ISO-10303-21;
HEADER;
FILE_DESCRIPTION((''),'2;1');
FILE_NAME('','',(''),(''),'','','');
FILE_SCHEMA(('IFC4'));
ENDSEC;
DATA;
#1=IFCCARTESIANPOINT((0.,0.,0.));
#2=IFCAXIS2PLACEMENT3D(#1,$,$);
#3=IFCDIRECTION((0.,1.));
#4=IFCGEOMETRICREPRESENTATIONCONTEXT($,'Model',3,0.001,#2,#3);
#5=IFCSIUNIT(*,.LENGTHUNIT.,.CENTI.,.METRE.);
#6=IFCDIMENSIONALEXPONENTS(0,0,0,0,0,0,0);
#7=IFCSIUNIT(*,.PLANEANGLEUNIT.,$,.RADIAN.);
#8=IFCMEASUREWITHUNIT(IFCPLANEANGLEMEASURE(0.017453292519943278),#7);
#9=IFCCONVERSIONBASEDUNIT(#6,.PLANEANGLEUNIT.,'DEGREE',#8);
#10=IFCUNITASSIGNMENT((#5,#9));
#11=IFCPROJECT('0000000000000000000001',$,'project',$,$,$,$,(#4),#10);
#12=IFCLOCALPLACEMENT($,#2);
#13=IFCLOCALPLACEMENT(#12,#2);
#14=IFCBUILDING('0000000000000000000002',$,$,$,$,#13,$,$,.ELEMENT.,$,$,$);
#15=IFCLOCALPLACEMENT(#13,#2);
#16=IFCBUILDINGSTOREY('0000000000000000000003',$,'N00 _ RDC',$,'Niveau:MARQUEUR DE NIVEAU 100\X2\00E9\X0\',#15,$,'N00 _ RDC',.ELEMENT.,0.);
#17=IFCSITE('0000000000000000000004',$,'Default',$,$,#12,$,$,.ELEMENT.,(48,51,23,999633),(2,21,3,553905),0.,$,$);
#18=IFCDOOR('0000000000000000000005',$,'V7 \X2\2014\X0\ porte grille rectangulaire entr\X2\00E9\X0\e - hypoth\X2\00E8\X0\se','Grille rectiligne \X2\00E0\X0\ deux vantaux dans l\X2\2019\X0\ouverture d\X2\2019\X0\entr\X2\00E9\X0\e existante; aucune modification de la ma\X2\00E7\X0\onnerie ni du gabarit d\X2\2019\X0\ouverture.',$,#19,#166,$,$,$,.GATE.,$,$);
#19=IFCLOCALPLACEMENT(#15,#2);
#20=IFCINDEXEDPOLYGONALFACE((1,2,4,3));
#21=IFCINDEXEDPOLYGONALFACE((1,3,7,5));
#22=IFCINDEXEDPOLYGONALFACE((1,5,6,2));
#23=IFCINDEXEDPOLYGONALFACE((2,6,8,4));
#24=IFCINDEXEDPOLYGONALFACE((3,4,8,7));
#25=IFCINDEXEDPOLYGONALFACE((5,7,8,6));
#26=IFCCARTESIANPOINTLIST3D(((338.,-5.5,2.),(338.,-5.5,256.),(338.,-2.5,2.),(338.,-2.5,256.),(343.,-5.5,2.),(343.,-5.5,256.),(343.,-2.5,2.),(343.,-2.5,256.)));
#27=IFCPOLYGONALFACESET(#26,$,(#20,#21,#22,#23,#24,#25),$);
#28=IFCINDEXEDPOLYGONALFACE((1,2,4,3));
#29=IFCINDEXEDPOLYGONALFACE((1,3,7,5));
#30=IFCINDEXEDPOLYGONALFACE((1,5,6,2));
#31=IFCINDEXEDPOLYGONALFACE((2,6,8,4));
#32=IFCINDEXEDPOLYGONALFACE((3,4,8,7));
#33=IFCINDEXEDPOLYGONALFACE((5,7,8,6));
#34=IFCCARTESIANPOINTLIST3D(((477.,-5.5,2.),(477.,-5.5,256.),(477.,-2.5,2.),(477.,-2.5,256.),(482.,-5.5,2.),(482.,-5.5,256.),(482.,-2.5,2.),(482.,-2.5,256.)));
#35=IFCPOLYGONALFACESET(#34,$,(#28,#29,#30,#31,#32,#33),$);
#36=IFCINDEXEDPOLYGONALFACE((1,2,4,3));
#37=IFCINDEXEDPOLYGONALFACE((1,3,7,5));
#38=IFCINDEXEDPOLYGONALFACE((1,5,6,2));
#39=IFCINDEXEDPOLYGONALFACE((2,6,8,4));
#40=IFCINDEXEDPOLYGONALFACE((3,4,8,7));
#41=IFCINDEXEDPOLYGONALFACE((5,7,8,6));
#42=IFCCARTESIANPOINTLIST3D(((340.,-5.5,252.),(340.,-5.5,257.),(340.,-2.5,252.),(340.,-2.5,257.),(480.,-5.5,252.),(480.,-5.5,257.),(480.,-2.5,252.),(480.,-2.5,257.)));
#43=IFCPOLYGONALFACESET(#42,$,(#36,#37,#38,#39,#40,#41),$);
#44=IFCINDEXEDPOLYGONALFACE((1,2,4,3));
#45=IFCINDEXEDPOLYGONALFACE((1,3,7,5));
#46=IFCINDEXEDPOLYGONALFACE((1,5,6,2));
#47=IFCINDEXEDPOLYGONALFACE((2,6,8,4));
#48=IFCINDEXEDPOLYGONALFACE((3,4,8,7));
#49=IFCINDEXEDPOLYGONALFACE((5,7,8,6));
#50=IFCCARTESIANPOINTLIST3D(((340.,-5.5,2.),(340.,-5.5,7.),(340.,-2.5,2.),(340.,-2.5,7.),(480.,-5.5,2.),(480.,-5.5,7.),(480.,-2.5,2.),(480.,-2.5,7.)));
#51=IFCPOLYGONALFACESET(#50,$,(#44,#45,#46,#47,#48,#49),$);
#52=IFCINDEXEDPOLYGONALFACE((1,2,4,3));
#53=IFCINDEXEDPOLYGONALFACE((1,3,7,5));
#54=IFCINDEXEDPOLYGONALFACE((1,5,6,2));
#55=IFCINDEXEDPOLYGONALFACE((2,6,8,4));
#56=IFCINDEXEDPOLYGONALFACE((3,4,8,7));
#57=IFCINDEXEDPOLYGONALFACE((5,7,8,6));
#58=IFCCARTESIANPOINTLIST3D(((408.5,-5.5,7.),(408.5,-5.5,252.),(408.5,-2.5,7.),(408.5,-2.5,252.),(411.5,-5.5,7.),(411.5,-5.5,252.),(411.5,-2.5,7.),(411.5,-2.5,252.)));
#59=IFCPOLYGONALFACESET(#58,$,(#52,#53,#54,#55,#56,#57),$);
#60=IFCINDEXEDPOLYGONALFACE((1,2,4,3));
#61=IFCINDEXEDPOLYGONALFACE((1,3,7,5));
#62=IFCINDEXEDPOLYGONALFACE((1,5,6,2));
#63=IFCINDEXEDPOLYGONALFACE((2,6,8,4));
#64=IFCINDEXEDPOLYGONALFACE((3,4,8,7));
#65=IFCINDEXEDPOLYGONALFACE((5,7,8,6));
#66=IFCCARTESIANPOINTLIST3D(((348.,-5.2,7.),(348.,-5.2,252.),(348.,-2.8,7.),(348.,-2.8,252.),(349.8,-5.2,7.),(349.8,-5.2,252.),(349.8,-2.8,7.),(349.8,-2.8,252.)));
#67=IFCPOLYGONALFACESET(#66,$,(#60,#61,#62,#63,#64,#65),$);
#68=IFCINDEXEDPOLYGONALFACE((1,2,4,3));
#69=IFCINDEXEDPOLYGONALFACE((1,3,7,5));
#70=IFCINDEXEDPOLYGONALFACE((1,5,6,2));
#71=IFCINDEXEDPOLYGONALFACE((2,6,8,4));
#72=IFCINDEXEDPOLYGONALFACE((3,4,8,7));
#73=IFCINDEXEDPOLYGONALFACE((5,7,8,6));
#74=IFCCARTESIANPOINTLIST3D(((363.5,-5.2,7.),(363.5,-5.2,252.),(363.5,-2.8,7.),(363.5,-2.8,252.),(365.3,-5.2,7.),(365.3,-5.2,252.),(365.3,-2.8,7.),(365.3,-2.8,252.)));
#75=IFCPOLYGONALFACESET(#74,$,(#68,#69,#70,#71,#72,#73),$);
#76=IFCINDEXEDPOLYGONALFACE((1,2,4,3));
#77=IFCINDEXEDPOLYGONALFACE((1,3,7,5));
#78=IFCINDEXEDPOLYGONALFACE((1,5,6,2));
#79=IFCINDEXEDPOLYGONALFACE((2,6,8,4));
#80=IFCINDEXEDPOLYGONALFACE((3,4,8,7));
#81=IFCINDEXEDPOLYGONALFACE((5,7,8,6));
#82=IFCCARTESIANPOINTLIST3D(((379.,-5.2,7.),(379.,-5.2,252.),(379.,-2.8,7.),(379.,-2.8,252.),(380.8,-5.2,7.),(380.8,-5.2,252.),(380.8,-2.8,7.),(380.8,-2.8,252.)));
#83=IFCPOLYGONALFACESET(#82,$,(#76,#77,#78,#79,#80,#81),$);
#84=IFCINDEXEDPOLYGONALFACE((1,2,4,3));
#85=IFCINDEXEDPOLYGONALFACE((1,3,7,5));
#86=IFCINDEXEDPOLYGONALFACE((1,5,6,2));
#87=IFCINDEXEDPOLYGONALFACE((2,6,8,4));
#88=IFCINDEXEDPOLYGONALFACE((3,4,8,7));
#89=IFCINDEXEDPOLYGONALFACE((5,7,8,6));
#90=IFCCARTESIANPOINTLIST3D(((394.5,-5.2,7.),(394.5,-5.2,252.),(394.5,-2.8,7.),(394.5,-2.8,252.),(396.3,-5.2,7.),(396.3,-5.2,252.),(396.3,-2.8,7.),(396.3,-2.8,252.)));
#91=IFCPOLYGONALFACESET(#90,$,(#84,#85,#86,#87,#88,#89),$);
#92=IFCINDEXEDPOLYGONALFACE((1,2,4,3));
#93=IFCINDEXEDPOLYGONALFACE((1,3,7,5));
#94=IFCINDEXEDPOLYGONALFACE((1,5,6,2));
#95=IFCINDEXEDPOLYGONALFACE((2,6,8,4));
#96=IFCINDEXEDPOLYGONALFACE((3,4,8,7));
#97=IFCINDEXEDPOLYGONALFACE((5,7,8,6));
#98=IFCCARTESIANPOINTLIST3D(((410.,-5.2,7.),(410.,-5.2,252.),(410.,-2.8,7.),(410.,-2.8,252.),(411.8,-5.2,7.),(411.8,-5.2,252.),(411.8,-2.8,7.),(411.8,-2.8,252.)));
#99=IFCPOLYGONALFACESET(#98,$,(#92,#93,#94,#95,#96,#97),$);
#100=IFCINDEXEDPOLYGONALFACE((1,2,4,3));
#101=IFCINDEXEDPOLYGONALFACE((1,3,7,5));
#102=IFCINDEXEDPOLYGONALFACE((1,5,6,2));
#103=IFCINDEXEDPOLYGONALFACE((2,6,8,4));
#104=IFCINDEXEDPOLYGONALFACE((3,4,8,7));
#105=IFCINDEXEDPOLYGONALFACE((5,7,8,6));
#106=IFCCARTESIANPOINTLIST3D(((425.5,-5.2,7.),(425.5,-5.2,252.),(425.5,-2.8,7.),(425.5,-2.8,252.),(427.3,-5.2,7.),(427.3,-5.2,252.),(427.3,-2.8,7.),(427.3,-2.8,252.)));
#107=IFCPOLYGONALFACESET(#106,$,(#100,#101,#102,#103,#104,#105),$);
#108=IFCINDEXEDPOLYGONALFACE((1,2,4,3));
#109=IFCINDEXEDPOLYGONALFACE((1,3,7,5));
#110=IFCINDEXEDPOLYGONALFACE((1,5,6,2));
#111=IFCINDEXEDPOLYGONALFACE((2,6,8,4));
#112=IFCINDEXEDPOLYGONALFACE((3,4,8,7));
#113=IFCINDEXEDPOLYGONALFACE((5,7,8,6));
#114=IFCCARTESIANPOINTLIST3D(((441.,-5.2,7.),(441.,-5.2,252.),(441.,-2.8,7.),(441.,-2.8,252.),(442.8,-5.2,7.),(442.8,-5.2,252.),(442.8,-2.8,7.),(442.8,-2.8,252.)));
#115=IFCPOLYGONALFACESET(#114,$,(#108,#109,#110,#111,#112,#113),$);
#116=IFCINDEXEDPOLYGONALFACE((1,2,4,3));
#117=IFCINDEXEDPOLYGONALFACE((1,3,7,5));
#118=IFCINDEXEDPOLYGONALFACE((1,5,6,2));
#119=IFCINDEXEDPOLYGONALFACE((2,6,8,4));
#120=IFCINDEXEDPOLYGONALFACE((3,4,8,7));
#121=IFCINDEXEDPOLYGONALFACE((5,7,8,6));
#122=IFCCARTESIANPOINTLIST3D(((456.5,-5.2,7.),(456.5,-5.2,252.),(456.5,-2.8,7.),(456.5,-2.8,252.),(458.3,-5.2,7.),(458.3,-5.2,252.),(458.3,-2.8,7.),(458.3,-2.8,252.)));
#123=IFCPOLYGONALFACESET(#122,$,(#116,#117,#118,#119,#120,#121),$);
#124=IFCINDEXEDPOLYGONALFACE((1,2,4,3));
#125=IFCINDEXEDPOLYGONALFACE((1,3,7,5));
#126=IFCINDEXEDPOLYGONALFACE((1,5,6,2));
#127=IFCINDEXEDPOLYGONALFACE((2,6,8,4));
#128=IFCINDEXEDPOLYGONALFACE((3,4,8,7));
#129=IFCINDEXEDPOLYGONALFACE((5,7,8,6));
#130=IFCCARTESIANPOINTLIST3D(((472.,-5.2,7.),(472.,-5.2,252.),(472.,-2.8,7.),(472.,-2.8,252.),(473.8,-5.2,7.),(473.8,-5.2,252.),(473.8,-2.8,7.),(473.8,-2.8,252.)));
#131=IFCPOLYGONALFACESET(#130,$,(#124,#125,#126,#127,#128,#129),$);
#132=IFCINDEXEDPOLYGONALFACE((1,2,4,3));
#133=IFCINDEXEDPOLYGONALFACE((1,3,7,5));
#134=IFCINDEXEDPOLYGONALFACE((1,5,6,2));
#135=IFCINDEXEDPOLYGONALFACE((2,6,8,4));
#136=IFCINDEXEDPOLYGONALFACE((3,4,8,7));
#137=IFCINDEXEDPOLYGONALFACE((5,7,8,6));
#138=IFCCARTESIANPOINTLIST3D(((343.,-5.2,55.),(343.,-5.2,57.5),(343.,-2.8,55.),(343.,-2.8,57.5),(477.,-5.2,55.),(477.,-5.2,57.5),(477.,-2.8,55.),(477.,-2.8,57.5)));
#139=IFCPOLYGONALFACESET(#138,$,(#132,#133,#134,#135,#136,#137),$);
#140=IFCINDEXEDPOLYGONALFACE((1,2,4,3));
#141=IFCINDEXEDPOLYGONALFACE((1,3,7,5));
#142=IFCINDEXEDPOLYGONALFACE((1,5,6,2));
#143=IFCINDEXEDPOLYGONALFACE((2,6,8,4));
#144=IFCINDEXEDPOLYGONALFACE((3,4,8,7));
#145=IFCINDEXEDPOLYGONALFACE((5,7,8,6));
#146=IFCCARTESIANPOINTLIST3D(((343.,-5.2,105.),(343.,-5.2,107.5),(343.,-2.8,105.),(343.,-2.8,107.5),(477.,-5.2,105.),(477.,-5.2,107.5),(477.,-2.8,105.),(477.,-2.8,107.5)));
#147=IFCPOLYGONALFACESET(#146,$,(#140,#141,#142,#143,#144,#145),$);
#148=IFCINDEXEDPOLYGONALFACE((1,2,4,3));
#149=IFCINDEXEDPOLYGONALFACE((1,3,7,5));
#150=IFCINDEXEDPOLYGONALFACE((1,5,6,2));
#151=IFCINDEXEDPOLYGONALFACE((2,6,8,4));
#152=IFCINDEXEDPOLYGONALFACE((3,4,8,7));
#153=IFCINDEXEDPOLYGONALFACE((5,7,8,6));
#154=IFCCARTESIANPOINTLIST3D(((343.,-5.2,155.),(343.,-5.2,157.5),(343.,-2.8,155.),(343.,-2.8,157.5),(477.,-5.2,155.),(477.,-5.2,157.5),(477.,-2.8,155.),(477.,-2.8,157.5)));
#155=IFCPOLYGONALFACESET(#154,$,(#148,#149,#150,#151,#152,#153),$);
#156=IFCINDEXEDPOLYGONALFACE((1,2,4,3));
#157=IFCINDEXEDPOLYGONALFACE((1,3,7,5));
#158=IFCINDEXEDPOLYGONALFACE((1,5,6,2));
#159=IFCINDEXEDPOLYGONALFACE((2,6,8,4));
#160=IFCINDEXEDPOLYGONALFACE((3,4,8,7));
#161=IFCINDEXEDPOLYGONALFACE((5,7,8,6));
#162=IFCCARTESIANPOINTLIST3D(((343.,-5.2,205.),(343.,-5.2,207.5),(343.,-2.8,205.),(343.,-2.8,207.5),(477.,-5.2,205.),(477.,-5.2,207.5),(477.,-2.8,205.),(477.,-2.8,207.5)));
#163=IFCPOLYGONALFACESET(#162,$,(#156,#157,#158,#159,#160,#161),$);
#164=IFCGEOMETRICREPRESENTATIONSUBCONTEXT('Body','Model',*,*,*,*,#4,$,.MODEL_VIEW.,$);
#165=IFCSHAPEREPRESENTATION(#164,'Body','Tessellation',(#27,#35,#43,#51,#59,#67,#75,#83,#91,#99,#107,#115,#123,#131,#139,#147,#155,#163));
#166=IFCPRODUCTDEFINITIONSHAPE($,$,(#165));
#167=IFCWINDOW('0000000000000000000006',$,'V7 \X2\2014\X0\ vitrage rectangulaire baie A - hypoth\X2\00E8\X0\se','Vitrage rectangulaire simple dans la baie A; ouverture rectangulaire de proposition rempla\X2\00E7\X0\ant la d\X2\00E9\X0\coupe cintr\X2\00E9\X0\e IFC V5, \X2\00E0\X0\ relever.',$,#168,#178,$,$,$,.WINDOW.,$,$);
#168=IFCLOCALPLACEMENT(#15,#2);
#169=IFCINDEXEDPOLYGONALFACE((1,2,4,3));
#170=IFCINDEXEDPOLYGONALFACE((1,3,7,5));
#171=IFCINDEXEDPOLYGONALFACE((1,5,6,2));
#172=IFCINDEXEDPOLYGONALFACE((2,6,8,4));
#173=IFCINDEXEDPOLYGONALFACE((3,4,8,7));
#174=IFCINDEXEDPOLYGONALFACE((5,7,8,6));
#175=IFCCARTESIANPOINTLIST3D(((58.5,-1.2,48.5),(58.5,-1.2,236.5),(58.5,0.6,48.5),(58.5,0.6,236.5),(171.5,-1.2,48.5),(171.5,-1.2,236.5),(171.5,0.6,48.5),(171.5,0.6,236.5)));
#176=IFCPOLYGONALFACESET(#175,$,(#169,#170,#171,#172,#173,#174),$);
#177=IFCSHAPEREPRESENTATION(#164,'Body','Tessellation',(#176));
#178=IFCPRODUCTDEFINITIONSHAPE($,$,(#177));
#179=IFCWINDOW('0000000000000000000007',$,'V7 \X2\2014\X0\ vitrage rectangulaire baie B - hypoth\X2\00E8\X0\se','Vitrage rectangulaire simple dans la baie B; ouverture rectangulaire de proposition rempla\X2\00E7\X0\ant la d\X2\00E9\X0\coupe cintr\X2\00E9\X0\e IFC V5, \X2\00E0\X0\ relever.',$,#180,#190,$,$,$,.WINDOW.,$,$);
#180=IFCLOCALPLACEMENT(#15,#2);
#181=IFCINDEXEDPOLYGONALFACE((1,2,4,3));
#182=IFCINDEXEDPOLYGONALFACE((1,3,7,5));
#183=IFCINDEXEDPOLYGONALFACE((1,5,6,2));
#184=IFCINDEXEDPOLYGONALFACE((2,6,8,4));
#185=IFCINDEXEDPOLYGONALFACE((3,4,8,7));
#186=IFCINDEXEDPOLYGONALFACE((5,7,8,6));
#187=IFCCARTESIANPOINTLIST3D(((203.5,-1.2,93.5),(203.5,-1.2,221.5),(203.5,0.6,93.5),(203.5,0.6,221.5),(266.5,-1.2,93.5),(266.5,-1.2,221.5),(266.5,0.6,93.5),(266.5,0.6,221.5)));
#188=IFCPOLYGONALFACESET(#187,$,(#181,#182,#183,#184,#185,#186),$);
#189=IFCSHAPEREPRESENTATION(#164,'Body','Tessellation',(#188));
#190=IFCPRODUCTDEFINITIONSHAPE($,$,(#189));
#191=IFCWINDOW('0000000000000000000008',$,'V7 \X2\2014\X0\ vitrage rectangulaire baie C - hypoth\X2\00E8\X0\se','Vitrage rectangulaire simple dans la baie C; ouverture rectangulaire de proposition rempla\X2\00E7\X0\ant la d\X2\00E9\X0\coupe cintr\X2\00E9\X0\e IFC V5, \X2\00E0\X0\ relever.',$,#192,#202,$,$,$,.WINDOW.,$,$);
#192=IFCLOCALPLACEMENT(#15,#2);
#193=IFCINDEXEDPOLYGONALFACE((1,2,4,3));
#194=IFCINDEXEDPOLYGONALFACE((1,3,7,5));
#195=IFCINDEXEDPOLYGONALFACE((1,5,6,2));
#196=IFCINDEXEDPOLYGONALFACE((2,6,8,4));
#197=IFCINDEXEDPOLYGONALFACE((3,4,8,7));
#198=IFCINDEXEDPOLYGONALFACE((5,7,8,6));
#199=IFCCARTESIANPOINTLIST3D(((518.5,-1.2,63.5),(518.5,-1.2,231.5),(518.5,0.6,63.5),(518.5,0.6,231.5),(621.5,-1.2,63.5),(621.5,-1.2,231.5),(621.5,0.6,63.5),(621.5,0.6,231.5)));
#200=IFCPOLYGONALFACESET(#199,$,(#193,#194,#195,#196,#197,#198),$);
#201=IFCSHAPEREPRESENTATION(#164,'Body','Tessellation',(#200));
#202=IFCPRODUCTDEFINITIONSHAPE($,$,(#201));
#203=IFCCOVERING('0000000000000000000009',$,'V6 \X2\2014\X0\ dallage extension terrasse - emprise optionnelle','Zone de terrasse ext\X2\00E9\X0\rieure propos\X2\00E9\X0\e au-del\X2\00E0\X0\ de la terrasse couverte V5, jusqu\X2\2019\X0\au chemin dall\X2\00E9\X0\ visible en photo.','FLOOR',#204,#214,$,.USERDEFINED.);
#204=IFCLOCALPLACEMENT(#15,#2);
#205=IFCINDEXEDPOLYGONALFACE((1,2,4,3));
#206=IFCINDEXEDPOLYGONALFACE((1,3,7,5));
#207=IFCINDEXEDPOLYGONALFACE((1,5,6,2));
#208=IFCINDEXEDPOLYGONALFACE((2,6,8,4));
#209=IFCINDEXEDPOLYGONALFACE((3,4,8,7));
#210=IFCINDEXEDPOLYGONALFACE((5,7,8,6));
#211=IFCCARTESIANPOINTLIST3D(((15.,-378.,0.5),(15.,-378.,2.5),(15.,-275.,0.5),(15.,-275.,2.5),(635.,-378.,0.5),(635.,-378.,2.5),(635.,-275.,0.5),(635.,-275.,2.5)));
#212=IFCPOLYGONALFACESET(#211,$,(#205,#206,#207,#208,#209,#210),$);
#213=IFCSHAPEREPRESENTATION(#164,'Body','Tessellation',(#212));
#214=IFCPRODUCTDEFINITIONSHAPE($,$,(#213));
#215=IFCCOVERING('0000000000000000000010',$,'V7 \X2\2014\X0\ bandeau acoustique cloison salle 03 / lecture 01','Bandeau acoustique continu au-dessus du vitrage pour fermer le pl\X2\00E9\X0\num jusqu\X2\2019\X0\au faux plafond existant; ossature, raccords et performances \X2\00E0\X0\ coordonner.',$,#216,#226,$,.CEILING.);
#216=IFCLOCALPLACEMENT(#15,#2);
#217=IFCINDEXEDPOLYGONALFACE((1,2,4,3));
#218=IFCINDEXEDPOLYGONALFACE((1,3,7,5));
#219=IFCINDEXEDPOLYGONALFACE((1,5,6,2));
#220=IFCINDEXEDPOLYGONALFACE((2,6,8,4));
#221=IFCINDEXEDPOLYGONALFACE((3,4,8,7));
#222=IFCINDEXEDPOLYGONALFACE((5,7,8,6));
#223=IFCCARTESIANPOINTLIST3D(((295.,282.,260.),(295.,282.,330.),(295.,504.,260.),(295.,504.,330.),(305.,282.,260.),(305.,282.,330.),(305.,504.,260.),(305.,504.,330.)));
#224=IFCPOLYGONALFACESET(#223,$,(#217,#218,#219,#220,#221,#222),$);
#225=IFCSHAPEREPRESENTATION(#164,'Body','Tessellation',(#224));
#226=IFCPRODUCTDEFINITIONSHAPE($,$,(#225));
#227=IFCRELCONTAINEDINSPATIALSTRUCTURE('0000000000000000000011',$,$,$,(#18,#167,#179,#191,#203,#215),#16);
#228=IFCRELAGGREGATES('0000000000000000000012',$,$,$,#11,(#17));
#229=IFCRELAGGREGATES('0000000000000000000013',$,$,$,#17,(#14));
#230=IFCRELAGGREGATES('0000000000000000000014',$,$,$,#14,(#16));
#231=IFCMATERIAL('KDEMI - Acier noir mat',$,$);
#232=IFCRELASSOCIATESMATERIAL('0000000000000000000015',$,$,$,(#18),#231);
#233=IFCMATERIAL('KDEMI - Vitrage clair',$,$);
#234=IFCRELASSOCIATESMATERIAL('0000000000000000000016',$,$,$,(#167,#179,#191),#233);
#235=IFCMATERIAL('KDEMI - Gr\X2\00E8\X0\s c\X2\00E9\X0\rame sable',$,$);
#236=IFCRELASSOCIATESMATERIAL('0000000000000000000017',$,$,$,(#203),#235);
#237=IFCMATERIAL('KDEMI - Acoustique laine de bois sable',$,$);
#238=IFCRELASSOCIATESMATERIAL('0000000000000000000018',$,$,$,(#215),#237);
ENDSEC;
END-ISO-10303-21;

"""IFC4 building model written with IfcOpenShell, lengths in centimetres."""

from ifc_helpers import new_model, entity, si_unit, converted_unit, direction, frame, frame_2d, origin, origin_with_axes, place, context, subcontext, project, spatial, rectangle, extrude, material, element, save


model = new_model("IFC4")

# Units and contexts
model_context = context("Model", 3, precision=0.001, world=origin(), true_north=direction((0.0, 1.0)))
body_context = subcontext(model_context, "Body", "Model", "MODEL_VIEW")
ifc_project = project(units=[si_unit("LENGTHUNIT", "METRE", prefix="CENTI"), converted_unit("PLANEANGLEUNIT", "DEGREE", entity("IfcPlaneAngleMeasure", 0.017453292519943278), si_unit("PLANEANGLEUNIT", "RADIAN"), dimensions=[0, 0, 0, 0, 0, 0, 0])], contexts=[model_context])

# Site, building, storey
site_placement = place(None, origin())
site = spatial("IfcSite", under=ifc_project, at=site_placement, Name="Default", CompositionType="ELEMENT", RefLatitude=(48, 51, 23, 999633), RefLongitude=(2, 21, 3, 553905), RefElevation=0.0)
building_placement = place(site_placement, origin())
building = spatial("IfcBuilding", under=site, at=building_placement, CompositionType="ELEMENT")
storey_placement = place(building_placement, origin())
storey = spatial("IfcBuildingStorey", under=building, at=storey_placement, Name="N00 _ RDC", ObjectType="Niveau:MARQUEUR DE NIVEAU 100é", LongName="N00 _ RDC", CompositionType="ELEMENT", Elevation=0.0)

# Shared definitions
ifc_material_1 = material(Name="KDEMI - Acier noir mat")

# Shared definitions
ifc_material_2 = material(Name="KDEMI - Vitrage clair")

# Door
door_1_placement = place(storey_placement, origin_with_axes())
element("IfcDoor", 1, at=door_1_placement, inside=storey, material=ifc_material_1, Name="V7 — porte grille rectangulaire entrée - hypothèse", Description="Grille rectiligne à deux vantaux dans l’ouverture d’entrée existante; aucune modification de la maçonnerie ni du gabarit d’ouverture.", PredefinedType="GATE", context=body_context, shape_type="SweptSolid", body=[
    extrude(rectangle(XDim=5.0, YDim=3.0, at=frame_2d((340.5, -4.0))), frame((0.0, 0.0, 2.0)), (0.0, 0.0, 1.0), 254.0),
    extrude(rectangle(XDim=5.0, YDim=3.0, at=frame_2d((479.5, -4.0))), frame((0.0, 0.0, 2.0)), (0.0, 0.0, 1.0), 254.0),
    extrude(rectangle(XDim=140.0, YDim=3.0, at=frame_2d((410.0, -4.0))), frame((0.0, 0.0, 252.0)), (0.0, 0.0, 1.0), 5.0),
    extrude(rectangle(XDim=140.0, YDim=3.0, at=frame_2d((410.0, -4.0))), frame((0.0, 0.0, 2.0)), (0.0, 0.0, 1.0), 5.0),
    extrude(rectangle(XDim=3.0, YDim=3.0, at=frame_2d((410.0, -4.0))), frame((0.0, 0.0, 7.0)), (0.0, 0.0, 1.0), 245.0),
    extrude(rectangle(XDim=1.8, YDim=2.4, at=frame_2d((348.9, -4.0))), frame((0.0, 0.0, 7.0)), (0.0, 0.0, 1.0), 245.0),
    extrude(rectangle(XDim=1.8, YDim=2.4, at=frame_2d((364.4, -4.0))), frame((0.0, 0.0, 7.0)), (0.0, 0.0, 1.0), 245.0),
    extrude(rectangle(XDim=1.8, YDim=2.4, at=frame_2d((379.9, -4.0))), frame((0.0, 0.0, 7.0)), (0.0, 0.0, 1.0), 245.0),
    extrude(rectangle(XDim=1.8, YDim=2.4, at=frame_2d((395.4, -4.0))), frame((0.0, 0.0, 7.0)), (0.0, 0.0, 1.0), 245.0),
    extrude(rectangle(XDim=1.8, YDim=2.4, at=frame_2d((410.9, -4.0))), frame((0.0, 0.0, 7.0)), (0.0, 0.0, 1.0), 245.0),
    extrude(rectangle(XDim=1.8, YDim=2.4, at=frame_2d((426.4, -4.0))), frame((0.0, 0.0, 7.0)), (0.0, 0.0, 1.0), 245.0),
    extrude(rectangle(XDim=1.8, YDim=2.4, at=frame_2d((441.9, -4.0))), frame((0.0, 0.0, 7.0)), (0.0, 0.0, 1.0), 245.0),
    extrude(rectangle(XDim=1.8, YDim=2.4, at=frame_2d((457.4, -4.0))), frame((0.0, 0.0, 7.0)), (0.0, 0.0, 1.0), 245.0),
    extrude(rectangle(XDim=1.8, YDim=2.4, at=frame_2d((472.9, -4.0))), frame((0.0, 0.0, 7.0)), (0.0, 0.0, 1.0), 245.0),
    extrude(rectangle(XDim=134.0, YDim=2.4, at=frame_2d((410.0, -4.0))), frame((0.0, 0.0, 55.0)), (0.0, 0.0, 1.0), 2.5),
    extrude(rectangle(XDim=134.0, YDim=2.4, at=frame_2d((410.0, -4.0))), frame((0.0, 0.0, 105.0)), (0.0, 0.0, 1.0), 2.5),
    extrude(rectangle(XDim=134.0, YDim=2.4, at=frame_2d((410.0, -4.0))), frame((0.0, 0.0, 155.0)), (0.0, 0.0, 1.0), 2.5),
    extrude(rectangle(XDim=134.0, YDim=2.4, at=frame_2d((410.0, -4.0))), frame((0.0, 0.0, 205.0)), (0.0, 0.0, 1.0), 2.5),
])

# Windows
window_1_placement = place(storey_placement, origin_with_axes())
element("IfcWindow", 2, at=window_1_placement, inside=storey, material=ifc_material_2, Name="V7 — vitrage rectangulaire baie A - hypothèse", Description="Vitrage rectangulaire simple dans la baie A; ouverture rectangulaire de proposition remplaçant la découpe cintrée IFC V5, à relever.", PredefinedType="WINDOW", context=body_context, shape_type="SweptSolid", body=[
    extrude(rectangle(XDim=113.0, YDim=1.8, at=frame_2d((115.0, -0.3))), frame((0.0, 0.0, 48.5)), (0.0, 0.0, 1.0), 188.0),
])
window_2_placement = place(storey_placement, origin_with_axes())
element("IfcWindow", 3, at=window_2_placement, inside=storey, material=ifc_material_2, Name="V7 — vitrage rectangulaire baie B - hypothèse", Description="Vitrage rectangulaire simple dans la baie B; ouverture rectangulaire de proposition remplaçant la découpe cintrée IFC V5, à relever.", PredefinedType="WINDOW", context=body_context, shape_type="SweptSolid", body=[
    extrude(rectangle(XDim=63.0, YDim=1.8, at=frame_2d((235.0, -0.3))), frame((0.0, 0.0, 93.5)), (0.0, 0.0, 1.0), 128.0),
])
window_3_placement = place(storey_placement, origin_with_axes())
element("IfcWindow", 4, at=window_3_placement, inside=storey, material=ifc_material_2, Name="V7 — vitrage rectangulaire baie C - hypothèse", Description="Vitrage rectangulaire simple dans la baie C; ouverture rectangulaire de proposition remplaçant la découpe cintrée IFC V5, à relever.", PredefinedType="WINDOW", context=body_context, shape_type="SweptSolid", body=[
    extrude(rectangle(XDim=103.0, YDim=1.8, at=frame_2d((570.0, -0.3))), frame((0.0, 0.0, 63.5)), (0.0, 0.0, 1.0), 168.0),
])

# Coverings
ifc_material_3 = material(Name="KDEMI - Grès cérame sable")
covering_1_placement = place(storey_placement, origin_with_axes())
element("IfcCovering", 5, at=covering_1_placement, inside=storey, material=ifc_material_3, Name="V6 — dallage extension terrasse - emprise optionnelle", Description="Zone de terrasse extérieure proposée au-delà de la terrasse couverte V5, jusqu’au chemin dallé visible en photo.", ObjectType="FLOOR", PredefinedType="USERDEFINED", context=body_context, shape_type="SweptSolid", body=[
    extrude(rectangle(XDim=620.0, YDim=103.0, at=frame_2d((325.0, -326.5))), frame((0.0, 0.0, 0.5)), (0.0, 0.0, 1.0), 2.0),
])
ifc_material_4 = material(Name="KDEMI - Acoustique laine de bois sable")
covering_2_placement = place(storey_placement, origin_with_axes())
element("IfcCovering", 6, at=covering_2_placement, inside=storey, material=ifc_material_4, Name="V7 — bandeau acoustique cloison salle 03 / lecture 01", Description="Bandeau acoustique continu au-dessus du vitrage pour fermer le plénum jusqu’au faux plafond existant; ossature, raccords et performances à coordonner.", PredefinedType="CEILING", context=body_context, shape_type="SweptSolid", body=[
    extrude(rectangle(XDim=10.0, YDim=222.0, at=frame_2d((300.0, 393.0))), frame((0.0, 0.0, 260.0)), (0.0, 0.0, 1.0), 70.0),
])

save(model, "model.ifc")
